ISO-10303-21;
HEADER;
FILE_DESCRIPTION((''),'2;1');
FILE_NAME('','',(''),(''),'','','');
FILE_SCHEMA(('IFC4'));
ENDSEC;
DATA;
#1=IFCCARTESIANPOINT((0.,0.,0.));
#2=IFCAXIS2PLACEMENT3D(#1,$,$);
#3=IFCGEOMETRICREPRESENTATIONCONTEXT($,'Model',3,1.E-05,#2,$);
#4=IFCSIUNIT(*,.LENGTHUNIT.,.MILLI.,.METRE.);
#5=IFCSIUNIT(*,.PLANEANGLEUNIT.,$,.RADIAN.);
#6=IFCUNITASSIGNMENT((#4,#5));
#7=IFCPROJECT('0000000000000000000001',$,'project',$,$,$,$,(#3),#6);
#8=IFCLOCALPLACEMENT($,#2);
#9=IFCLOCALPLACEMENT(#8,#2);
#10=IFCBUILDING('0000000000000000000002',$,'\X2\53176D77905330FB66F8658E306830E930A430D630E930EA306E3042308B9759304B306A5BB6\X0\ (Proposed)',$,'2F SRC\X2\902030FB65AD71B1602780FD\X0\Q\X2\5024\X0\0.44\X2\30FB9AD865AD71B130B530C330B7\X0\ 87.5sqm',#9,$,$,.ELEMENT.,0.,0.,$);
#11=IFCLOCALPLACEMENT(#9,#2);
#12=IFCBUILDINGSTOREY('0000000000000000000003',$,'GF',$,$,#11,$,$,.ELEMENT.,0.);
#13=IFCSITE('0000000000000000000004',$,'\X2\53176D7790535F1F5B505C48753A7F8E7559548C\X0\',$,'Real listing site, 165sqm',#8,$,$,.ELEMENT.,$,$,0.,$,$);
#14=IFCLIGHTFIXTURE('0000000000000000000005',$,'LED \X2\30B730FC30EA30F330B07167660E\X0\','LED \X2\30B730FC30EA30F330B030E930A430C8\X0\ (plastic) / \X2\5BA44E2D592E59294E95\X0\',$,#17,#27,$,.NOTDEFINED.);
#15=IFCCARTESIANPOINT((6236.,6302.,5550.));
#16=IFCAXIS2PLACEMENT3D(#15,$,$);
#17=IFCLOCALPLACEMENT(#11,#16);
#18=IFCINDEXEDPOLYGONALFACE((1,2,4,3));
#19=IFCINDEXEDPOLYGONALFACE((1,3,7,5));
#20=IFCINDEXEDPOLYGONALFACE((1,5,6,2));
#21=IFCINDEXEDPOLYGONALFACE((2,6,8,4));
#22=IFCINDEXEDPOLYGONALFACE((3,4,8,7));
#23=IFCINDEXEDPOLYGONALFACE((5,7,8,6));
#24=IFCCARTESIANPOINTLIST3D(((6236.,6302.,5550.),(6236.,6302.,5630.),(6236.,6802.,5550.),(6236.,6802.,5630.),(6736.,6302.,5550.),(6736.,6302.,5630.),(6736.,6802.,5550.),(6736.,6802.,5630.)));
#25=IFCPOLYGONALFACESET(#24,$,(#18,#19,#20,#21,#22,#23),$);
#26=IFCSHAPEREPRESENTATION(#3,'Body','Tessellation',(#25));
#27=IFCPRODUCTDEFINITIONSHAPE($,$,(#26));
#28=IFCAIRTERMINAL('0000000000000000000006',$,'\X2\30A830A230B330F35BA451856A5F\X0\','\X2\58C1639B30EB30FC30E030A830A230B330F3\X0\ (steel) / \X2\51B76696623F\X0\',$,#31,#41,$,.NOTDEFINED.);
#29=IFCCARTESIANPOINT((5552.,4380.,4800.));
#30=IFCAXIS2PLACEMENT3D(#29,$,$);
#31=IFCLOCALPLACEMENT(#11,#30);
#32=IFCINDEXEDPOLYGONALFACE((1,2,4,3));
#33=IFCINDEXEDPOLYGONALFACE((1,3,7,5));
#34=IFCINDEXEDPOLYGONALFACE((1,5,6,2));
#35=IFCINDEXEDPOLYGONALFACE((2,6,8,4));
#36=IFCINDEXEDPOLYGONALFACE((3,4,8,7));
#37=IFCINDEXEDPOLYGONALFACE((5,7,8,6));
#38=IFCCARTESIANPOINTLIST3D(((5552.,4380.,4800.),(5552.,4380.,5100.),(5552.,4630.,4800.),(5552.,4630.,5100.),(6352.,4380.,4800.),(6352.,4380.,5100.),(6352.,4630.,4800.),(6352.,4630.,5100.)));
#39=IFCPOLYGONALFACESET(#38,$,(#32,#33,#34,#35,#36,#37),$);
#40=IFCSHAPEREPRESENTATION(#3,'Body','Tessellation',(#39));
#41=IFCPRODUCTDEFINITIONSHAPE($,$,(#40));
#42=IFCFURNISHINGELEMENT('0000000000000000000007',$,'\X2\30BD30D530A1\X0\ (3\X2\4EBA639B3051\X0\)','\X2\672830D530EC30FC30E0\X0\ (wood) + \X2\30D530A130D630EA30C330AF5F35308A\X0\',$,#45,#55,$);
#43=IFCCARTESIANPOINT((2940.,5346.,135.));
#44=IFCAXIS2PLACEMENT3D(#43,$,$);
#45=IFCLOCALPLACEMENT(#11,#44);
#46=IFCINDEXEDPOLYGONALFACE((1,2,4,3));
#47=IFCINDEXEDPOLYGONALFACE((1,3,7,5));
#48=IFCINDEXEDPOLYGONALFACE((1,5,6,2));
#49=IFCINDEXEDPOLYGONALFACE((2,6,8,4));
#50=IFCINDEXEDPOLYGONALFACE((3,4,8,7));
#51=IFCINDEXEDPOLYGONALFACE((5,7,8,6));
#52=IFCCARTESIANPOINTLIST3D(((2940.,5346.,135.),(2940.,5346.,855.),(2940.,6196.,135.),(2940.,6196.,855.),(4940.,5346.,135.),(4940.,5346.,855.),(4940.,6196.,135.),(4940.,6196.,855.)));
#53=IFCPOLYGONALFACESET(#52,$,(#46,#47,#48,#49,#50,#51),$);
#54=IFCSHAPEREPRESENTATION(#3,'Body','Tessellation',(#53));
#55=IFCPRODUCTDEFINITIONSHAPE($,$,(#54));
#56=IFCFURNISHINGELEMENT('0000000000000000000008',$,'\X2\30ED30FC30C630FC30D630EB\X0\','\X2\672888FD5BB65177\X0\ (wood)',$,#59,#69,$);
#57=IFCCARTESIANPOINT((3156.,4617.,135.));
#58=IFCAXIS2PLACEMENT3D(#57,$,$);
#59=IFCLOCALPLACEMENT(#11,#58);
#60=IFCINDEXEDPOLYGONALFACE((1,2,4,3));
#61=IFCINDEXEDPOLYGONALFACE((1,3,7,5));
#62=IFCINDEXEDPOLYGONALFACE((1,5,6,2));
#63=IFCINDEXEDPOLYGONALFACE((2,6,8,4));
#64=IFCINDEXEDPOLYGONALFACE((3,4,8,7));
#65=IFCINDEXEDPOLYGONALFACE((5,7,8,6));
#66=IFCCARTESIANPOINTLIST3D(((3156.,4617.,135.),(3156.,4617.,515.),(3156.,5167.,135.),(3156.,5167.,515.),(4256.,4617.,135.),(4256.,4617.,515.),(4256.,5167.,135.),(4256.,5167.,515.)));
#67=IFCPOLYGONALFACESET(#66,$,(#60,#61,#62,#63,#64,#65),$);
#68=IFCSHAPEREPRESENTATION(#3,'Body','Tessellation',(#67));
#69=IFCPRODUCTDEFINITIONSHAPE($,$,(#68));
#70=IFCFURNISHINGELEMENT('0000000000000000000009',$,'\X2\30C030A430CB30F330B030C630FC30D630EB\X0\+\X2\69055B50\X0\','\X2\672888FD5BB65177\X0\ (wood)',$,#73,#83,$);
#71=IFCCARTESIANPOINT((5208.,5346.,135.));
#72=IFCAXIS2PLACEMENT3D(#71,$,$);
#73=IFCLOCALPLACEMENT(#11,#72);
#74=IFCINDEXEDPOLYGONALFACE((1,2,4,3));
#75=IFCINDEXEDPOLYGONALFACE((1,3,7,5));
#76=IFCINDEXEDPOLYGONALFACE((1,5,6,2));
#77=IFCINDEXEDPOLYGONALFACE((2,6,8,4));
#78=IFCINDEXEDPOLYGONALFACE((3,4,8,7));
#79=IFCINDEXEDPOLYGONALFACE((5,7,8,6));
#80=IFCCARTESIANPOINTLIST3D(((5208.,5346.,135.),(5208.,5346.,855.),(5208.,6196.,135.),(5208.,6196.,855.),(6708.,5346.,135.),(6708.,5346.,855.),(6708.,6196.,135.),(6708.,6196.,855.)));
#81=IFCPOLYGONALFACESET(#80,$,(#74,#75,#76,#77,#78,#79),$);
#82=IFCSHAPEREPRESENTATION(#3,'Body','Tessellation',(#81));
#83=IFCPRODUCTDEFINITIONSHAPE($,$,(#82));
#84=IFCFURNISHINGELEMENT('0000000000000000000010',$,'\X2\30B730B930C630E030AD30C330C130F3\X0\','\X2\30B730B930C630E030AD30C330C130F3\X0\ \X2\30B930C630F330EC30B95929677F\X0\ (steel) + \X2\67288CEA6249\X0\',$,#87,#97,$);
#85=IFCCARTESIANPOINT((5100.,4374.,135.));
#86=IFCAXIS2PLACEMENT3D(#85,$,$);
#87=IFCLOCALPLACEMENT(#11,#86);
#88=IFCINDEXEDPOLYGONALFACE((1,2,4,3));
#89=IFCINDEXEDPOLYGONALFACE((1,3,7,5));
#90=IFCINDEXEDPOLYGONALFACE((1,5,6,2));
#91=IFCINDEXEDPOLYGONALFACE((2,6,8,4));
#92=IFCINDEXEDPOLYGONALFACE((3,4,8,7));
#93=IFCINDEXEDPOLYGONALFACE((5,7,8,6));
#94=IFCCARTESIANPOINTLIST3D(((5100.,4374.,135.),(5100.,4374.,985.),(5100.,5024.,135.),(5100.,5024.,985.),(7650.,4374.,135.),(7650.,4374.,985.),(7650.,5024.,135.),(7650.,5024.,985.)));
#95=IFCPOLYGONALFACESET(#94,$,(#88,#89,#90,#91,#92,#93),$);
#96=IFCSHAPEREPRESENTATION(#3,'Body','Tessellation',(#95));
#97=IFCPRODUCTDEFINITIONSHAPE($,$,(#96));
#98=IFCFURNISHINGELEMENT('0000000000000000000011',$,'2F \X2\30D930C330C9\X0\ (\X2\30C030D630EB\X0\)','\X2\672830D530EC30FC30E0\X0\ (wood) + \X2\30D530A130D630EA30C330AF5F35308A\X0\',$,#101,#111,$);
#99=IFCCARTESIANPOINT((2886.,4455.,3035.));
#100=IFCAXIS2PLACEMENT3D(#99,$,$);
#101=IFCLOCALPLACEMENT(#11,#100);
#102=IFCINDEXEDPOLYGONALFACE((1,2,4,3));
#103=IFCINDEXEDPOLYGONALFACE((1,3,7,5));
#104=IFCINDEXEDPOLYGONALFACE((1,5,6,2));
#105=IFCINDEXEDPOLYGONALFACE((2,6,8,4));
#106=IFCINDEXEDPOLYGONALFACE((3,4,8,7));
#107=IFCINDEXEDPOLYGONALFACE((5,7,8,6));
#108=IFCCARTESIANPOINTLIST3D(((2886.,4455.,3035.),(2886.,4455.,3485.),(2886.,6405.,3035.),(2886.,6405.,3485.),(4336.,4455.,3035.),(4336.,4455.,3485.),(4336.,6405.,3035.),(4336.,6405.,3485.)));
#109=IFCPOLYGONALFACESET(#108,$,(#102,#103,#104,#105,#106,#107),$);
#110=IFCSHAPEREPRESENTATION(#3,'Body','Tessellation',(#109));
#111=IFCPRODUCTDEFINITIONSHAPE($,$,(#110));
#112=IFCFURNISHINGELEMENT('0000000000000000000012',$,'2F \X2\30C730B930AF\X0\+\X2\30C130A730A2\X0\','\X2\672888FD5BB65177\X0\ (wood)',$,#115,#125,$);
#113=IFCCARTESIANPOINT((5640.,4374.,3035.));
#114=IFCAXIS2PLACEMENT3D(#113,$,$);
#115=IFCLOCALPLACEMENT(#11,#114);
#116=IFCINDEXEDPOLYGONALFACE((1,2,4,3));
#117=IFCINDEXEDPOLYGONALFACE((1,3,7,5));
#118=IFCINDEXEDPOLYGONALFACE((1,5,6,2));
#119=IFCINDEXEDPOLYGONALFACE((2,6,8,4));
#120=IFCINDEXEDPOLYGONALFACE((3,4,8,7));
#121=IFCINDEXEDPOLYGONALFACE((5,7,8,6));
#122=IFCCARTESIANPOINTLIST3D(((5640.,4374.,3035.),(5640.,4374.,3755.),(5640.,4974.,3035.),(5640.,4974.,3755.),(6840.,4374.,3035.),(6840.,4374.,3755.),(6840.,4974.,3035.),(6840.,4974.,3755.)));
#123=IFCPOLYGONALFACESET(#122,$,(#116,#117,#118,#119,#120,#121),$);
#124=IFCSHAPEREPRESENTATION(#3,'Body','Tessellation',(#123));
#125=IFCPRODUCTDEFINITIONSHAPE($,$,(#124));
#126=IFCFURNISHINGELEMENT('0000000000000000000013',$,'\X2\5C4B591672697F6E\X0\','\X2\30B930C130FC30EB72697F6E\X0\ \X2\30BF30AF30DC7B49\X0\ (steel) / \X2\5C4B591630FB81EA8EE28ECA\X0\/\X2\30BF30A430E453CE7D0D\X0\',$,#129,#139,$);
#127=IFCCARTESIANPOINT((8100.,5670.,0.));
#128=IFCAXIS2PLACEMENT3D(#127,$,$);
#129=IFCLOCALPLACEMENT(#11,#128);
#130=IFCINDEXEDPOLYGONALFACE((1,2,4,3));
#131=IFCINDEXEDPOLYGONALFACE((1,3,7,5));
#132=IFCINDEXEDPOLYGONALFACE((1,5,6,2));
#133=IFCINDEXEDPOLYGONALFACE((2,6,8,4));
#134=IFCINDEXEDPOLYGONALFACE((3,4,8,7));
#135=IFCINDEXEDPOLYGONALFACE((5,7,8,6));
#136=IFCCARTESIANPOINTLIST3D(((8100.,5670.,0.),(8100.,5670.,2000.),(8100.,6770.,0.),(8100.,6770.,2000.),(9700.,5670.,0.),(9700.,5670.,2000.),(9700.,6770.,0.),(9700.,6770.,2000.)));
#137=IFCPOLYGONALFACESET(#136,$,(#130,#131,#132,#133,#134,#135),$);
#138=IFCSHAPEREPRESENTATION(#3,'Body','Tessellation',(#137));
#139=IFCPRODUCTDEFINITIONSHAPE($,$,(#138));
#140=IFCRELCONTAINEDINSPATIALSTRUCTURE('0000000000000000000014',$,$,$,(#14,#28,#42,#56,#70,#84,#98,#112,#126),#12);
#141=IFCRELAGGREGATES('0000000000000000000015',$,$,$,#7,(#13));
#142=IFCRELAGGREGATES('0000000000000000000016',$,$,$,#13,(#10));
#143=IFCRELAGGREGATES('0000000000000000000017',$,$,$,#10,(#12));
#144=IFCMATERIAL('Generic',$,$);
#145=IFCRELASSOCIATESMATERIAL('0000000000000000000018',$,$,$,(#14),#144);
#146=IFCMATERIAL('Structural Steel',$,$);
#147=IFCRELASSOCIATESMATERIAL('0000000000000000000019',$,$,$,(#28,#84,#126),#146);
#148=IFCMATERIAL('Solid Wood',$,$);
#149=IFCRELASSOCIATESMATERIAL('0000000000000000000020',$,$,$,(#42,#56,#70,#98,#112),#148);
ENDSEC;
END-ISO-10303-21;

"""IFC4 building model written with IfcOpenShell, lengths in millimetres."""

from ifc_helpers import new_model, si_unit, frame, frame_2d, origin, place, context, project, spatial, rectangle, extrude, material, element, save


model = new_model("IFC4")

# Units and contexts
model_context = context("Model", 3, precision=1e-05, world=origin())
ifc_project = project(units=[si_unit("LENGTHUNIT", "METRE", prefix="MILLI"), si_unit("PLANEANGLEUNIT", "RADIAN")], contexts=[model_context])

# Site, building, storey
site_placement = place(None, origin())
site = spatial("IfcSite", under=ifc_project, at=site_placement, Name="北海道弟子屈町美留和", ObjectType="Real listing site, 165sqm", CompositionType="ELEMENT", RefElevation=0.0)
building_placement = place(site_placement, origin())
building = spatial("IfcBuilding", under=site, at=building_placement, Name="北海道・書斎とライブラリのある静かな家 (Proposed)", ObjectType="2F SRC造・断熱性能Q値0.44・高断熱サッシ 87.5sqm", CompositionType="ELEMENT", ElevationOfRefHeight=0.0, ElevationOfTerrain=0.0)
storey_placement = place(building_placement, origin())
storey = spatial("IfcBuildingStorey", under=building, at=storey_placement, Name="GF", CompositionType="ELEMENT", Elevation=0.0)

# Shared definitions
ifc_material_1 = material(Name="Solid Wood")

# Shared definitions
ifc_material_2 = material(Name="Generic")

# Shared definitions
ifc_material_3 = material(Name="Structural Steel")

# Light fixture
light_fixture_placement = place(storey_placement, frame((6236.0, 6302.0, 5550.0)))
element("IfcLightFixture", 1, at=light_fixture_placement, inside=storey, material=ifc_material_2, Name="LED シーリング照明", Description="LED シーリングライト (plastic) / 室中央天井", PredefinedType="NOTDEFINED", context=model_context, shape_type="SweptSolid", body=[
    extrude(rectangle(XDim=500.0, YDim=500.0, at=frame_2d((250.0, 250.0))), frame((6236.0, 6302.0, 5550.0)), (0.0, 0.0, 1.0), 80.0),
])

# Air terminal
air_terminal_1_placement = place(storey_placement, frame((5552.0, 4380.0, 4800.0)))
element("IfcAirTerminal", 2, at=air_terminal_1_placement, inside=storey, material=ifc_material_3, Name="エアコン室内機", Description="壁掛ルームエアコン (steel) / 冷暖房", PredefinedType="NOTDEFINED", context=model_context, shape_type="SweptSolid", body=[
    extrude(rectangle(XDim=800.0, YDim=250.0, at=frame_2d((400.0, 125.0))), frame((5552.0, 4380.0, 4800.0)), (0.0, 0.0, 1.0), 300.0),
])

# Furnishing elements
furnishing_1_placement = place(storey_placement, frame((2940.0, 5346.0, 135.0)))
element("IfcFurnishingElement", 3, at=furnishing_1_placement, inside=storey, material=ifc_material_1, Name="ソファ (3人掛け)", Description="木フレーム (wood) + ファブリック張り", context=model_context, shape_type="SweptSolid", body=[
    extrude(rectangle(XDim=2000.0, YDim=850.0, at=frame_2d((1000.0, 425.0))), frame((2940.0, 5346.0, 135.0)), (0.0, 0.0, 1.0), 720.0),
])
furnishing_2_placement = place(storey_placement, frame((3156.0, 4617.0, 135.0)))
element("IfcFurnishingElement", 4, at=furnishing_2_placement, inside=storey, material=ifc_material_1, Name="ローテーブル", Description="木製家具 (wood)", context=model_context, shape_type="SweptSolid", body=[
    extrude(rectangle(XDim=1100.0, YDim=550.0, at=frame_2d((550.0, 275.0))), frame((3156.0, 4617.0, 135.0)), (0.0, 0.0, 1.0), 380.0),
])
furnishing_3_placement = place(storey_placement, frame((5208.0, 5346.0, 135.0)))
element("IfcFurnishingElement", 5, at=furnishing_3_placement, inside=storey, material=ifc_material_1, Name="ダイニングテーブル+椅子", Description="木製家具 (wood)", context=model_context, shape_type="SweptSolid", body=[
    extrude(rectangle(XDim=1500.0, YDim=850.0, at=frame_2d((750.0, 425.0))), frame((5208.0, 5346.0, 135.0)), (0.0, 0.0, 1.0), 720.0),
])
furnishing_4_placement = place(storey_placement, frame((5100.0, 4374.0, 135.0)))
element("IfcFurnishingElement", 6, at=furnishing_4_placement, inside=storey, material=ifc_material_3, Name="システムキッチン", Description="システムキッチン ステンレス天板 (steel) + 木質扉", context=model_context, shape_type="SweptSolid", body=[
    extrude(rectangle(XDim=2550.0, YDim=650.0, at=frame_2d((1275.0, 325.0))), frame((5100.0, 4374.0, 135.0)), (0.0, 0.0, 1.0), 850.0),
])
furnishing_5_placement = place(storey_placement, frame((2886.0, 4455.0, 3035.0)))
element("IfcFurnishingElement", 7, at=furnishing_5_placement, inside=storey, material=ifc_material_1, Name="2F ベッド (ダブル)", Description="木フレーム (wood) + ファブリック張り", context=model_context, shape_type="SweptSolid", body=[
    extrude(rectangle(XDim=1450.0, YDim=1950.0, at=frame_2d((725.0, 975.0))), frame((2886.0, 4455.0, 3035.0)), (0.0, 0.0, 1.0), 450.0),
])
furnishing_6_placement = place(storey_placement, frame((5640.0, 4374.0, 3035.0)))
element("IfcFurnishingElement", 8, at=furnishing_6_placement, inside=storey, material=ifc_material_1, Name="2F デスク+チェア", Description="木製家具 (wood)", context=model_context, shape_type="SweptSolid", body=[
    extrude(rectangle(XDim=1200.0, YDim=600.0, at=frame_2d((600.0, 300.0))), frame((5640.0, 4374.0, 3035.0)), (0.0, 0.0, 1.0), 720.0),
])
furnishing_7_placement = place(storey_placement, frame((8100.0, 5670.0, 0.0)))
element("IfcFurnishingElement", 9, at=furnishing_7_placement, inside=storey, material=ifc_material_3, Name="屋外物置", Description="スチール物置 タクボ等 (steel) / 屋外・自転車/タイヤ収納", context=model_context, shape_type="SweptSolid", body=[
    extrude(rectangle(XDim=1600.0, YDim=1100.0, at=frame_2d((800.0, 550.0))), frame((8100.0, 5670.0, 0.0)), (0.0, 0.0, 1.0), 2000.0),
])

save(model, "model.ifc")
